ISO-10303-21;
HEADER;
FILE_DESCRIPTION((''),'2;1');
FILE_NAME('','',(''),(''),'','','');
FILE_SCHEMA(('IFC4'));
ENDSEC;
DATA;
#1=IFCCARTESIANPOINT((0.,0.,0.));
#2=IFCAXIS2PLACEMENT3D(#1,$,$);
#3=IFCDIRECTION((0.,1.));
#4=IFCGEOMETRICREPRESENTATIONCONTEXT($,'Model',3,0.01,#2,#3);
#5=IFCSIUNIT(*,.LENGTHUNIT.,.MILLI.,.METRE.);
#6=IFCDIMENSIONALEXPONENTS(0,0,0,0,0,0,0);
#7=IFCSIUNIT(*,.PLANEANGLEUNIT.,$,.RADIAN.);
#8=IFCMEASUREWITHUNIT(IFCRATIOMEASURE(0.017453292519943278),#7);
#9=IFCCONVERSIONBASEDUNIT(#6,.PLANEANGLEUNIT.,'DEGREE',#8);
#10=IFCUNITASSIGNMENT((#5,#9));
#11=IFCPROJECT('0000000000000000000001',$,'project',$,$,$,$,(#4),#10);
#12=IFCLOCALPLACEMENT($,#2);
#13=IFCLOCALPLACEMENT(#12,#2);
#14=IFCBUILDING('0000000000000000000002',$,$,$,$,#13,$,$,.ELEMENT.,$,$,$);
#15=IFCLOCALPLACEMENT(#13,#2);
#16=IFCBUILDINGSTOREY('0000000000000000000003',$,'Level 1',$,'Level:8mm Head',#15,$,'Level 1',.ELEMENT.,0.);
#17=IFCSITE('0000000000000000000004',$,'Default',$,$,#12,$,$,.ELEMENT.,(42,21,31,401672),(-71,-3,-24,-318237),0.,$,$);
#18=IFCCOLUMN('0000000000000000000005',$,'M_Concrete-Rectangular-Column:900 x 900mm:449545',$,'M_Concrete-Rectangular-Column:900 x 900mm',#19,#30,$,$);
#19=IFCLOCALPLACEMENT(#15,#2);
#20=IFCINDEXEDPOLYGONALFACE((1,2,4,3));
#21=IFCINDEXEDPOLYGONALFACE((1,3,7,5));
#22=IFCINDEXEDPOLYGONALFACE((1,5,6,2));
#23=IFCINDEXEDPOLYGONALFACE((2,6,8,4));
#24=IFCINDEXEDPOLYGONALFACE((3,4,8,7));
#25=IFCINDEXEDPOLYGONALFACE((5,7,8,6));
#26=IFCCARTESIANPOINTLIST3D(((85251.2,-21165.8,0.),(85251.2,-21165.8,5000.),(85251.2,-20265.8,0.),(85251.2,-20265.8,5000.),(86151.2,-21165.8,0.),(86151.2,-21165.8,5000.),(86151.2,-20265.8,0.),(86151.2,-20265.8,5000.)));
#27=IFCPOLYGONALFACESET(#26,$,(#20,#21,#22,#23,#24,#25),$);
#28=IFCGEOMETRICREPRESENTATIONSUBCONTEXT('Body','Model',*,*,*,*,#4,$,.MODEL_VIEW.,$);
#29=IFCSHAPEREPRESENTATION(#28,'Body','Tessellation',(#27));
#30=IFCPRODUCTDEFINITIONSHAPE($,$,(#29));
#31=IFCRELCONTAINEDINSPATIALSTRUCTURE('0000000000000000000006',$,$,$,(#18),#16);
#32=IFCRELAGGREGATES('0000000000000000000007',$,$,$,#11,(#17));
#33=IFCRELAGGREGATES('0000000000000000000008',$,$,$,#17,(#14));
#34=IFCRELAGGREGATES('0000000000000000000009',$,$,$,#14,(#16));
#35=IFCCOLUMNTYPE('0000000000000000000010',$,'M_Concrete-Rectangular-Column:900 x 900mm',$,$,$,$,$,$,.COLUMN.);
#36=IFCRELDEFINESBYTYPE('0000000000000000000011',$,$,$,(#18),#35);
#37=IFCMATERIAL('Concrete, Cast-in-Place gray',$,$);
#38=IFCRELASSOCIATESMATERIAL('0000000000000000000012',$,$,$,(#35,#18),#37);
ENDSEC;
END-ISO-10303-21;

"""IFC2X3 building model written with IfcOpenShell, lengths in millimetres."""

from ifc_helpers import new_model, entity, si_unit, converted_unit, direction, frame, origin, origin_2d_with_axis, place, context, subcontext, project, spatial, rectangle, extrude, source, transform, mapped, material, type_object, type_shapes, element, save


model = new_model("IFC2X3")

# Units and contexts
model_context = context("Model", 3, precision=0.01, world=origin(), true_north=direction((0.0, 1.0)))
body_context = subcontext(model_context, "Body", "Model", "MODEL_VIEW")
ifc_project = project(units=[si_unit("LENGTHUNIT", "METRE", prefix="MILLI"), converted_unit("PLANEANGLEUNIT", "DEGREE", entity("IfcRatioMeasure", 0.017453292519943278), si_unit("PLANEANGLEUNIT", "RADIAN"), dimensions=[0, 0, 0, 0, 0, 0, 0])], contexts=[model_context])

# Site, building, storey
site_placement = place(None, origin())
site = spatial("IfcSite", under=ifc_project, at=site_placement, Name="Default", CompositionType="ELEMENT", RefLatitude=(42, 21, 31, 401672), RefLongitude=(-71, -3, -24, -318237), RefElevation=0.0)
building_placement = place(site_placement, origin())
building = spatial("IfcBuilding", under=site, at=building_placement, CompositionType="ELEMENT")
storey_placement = place(building_placement, origin())
storey = spatial("IfcBuildingStorey", under=building, at=storey_placement, Name="Level 1", ObjectType="Level:8mm Head", LongName="Level 1", CompositionType="ELEMENT", Elevation=0.0)

# Column
ifc_material_1 = material(Name="Concrete, Cast-in-Place gray")
column_type_1 = type_object("IfcColumnType", Name="M_Concrete-Rectangular-Column:900 x 900mm", PredefinedType="COLUMN", material=ifc_material_1)
shared_shape_1 = source(origin(), body_context, "Body", "SweptSolid", [
    extrude(rectangle(XDim=900.0, YDim=900.0, at=origin_2d_with_axis()), frame((85701.2, -20715.8, 0.0), z_axis=(0.0, 0.0, 1.0), x_axis=(0.0, -1.0, 0.0)), (0.0, 0.0, 1.0), 5000.0),
])
type_shapes(column_type_1, [shared_shape_1])
column_1_placement = place(storey_placement, origin())
element("IfcColumn", 1, at=column_1_placement, inside=storey, type_object=column_type_1, material=ifc_material_1, Name="M_Concrete-Rectangular-Column:900 x 900mm:449545", ObjectType="M_Concrete-Rectangular-Column:900 x 900mm", context=body_context, shape_type="MappedRepresentation", body=[
    mapped(shared_shape_1, transform((0.0, 0.0, 0.0), scale=1.0)),
])

save(model, "model.ifc")
